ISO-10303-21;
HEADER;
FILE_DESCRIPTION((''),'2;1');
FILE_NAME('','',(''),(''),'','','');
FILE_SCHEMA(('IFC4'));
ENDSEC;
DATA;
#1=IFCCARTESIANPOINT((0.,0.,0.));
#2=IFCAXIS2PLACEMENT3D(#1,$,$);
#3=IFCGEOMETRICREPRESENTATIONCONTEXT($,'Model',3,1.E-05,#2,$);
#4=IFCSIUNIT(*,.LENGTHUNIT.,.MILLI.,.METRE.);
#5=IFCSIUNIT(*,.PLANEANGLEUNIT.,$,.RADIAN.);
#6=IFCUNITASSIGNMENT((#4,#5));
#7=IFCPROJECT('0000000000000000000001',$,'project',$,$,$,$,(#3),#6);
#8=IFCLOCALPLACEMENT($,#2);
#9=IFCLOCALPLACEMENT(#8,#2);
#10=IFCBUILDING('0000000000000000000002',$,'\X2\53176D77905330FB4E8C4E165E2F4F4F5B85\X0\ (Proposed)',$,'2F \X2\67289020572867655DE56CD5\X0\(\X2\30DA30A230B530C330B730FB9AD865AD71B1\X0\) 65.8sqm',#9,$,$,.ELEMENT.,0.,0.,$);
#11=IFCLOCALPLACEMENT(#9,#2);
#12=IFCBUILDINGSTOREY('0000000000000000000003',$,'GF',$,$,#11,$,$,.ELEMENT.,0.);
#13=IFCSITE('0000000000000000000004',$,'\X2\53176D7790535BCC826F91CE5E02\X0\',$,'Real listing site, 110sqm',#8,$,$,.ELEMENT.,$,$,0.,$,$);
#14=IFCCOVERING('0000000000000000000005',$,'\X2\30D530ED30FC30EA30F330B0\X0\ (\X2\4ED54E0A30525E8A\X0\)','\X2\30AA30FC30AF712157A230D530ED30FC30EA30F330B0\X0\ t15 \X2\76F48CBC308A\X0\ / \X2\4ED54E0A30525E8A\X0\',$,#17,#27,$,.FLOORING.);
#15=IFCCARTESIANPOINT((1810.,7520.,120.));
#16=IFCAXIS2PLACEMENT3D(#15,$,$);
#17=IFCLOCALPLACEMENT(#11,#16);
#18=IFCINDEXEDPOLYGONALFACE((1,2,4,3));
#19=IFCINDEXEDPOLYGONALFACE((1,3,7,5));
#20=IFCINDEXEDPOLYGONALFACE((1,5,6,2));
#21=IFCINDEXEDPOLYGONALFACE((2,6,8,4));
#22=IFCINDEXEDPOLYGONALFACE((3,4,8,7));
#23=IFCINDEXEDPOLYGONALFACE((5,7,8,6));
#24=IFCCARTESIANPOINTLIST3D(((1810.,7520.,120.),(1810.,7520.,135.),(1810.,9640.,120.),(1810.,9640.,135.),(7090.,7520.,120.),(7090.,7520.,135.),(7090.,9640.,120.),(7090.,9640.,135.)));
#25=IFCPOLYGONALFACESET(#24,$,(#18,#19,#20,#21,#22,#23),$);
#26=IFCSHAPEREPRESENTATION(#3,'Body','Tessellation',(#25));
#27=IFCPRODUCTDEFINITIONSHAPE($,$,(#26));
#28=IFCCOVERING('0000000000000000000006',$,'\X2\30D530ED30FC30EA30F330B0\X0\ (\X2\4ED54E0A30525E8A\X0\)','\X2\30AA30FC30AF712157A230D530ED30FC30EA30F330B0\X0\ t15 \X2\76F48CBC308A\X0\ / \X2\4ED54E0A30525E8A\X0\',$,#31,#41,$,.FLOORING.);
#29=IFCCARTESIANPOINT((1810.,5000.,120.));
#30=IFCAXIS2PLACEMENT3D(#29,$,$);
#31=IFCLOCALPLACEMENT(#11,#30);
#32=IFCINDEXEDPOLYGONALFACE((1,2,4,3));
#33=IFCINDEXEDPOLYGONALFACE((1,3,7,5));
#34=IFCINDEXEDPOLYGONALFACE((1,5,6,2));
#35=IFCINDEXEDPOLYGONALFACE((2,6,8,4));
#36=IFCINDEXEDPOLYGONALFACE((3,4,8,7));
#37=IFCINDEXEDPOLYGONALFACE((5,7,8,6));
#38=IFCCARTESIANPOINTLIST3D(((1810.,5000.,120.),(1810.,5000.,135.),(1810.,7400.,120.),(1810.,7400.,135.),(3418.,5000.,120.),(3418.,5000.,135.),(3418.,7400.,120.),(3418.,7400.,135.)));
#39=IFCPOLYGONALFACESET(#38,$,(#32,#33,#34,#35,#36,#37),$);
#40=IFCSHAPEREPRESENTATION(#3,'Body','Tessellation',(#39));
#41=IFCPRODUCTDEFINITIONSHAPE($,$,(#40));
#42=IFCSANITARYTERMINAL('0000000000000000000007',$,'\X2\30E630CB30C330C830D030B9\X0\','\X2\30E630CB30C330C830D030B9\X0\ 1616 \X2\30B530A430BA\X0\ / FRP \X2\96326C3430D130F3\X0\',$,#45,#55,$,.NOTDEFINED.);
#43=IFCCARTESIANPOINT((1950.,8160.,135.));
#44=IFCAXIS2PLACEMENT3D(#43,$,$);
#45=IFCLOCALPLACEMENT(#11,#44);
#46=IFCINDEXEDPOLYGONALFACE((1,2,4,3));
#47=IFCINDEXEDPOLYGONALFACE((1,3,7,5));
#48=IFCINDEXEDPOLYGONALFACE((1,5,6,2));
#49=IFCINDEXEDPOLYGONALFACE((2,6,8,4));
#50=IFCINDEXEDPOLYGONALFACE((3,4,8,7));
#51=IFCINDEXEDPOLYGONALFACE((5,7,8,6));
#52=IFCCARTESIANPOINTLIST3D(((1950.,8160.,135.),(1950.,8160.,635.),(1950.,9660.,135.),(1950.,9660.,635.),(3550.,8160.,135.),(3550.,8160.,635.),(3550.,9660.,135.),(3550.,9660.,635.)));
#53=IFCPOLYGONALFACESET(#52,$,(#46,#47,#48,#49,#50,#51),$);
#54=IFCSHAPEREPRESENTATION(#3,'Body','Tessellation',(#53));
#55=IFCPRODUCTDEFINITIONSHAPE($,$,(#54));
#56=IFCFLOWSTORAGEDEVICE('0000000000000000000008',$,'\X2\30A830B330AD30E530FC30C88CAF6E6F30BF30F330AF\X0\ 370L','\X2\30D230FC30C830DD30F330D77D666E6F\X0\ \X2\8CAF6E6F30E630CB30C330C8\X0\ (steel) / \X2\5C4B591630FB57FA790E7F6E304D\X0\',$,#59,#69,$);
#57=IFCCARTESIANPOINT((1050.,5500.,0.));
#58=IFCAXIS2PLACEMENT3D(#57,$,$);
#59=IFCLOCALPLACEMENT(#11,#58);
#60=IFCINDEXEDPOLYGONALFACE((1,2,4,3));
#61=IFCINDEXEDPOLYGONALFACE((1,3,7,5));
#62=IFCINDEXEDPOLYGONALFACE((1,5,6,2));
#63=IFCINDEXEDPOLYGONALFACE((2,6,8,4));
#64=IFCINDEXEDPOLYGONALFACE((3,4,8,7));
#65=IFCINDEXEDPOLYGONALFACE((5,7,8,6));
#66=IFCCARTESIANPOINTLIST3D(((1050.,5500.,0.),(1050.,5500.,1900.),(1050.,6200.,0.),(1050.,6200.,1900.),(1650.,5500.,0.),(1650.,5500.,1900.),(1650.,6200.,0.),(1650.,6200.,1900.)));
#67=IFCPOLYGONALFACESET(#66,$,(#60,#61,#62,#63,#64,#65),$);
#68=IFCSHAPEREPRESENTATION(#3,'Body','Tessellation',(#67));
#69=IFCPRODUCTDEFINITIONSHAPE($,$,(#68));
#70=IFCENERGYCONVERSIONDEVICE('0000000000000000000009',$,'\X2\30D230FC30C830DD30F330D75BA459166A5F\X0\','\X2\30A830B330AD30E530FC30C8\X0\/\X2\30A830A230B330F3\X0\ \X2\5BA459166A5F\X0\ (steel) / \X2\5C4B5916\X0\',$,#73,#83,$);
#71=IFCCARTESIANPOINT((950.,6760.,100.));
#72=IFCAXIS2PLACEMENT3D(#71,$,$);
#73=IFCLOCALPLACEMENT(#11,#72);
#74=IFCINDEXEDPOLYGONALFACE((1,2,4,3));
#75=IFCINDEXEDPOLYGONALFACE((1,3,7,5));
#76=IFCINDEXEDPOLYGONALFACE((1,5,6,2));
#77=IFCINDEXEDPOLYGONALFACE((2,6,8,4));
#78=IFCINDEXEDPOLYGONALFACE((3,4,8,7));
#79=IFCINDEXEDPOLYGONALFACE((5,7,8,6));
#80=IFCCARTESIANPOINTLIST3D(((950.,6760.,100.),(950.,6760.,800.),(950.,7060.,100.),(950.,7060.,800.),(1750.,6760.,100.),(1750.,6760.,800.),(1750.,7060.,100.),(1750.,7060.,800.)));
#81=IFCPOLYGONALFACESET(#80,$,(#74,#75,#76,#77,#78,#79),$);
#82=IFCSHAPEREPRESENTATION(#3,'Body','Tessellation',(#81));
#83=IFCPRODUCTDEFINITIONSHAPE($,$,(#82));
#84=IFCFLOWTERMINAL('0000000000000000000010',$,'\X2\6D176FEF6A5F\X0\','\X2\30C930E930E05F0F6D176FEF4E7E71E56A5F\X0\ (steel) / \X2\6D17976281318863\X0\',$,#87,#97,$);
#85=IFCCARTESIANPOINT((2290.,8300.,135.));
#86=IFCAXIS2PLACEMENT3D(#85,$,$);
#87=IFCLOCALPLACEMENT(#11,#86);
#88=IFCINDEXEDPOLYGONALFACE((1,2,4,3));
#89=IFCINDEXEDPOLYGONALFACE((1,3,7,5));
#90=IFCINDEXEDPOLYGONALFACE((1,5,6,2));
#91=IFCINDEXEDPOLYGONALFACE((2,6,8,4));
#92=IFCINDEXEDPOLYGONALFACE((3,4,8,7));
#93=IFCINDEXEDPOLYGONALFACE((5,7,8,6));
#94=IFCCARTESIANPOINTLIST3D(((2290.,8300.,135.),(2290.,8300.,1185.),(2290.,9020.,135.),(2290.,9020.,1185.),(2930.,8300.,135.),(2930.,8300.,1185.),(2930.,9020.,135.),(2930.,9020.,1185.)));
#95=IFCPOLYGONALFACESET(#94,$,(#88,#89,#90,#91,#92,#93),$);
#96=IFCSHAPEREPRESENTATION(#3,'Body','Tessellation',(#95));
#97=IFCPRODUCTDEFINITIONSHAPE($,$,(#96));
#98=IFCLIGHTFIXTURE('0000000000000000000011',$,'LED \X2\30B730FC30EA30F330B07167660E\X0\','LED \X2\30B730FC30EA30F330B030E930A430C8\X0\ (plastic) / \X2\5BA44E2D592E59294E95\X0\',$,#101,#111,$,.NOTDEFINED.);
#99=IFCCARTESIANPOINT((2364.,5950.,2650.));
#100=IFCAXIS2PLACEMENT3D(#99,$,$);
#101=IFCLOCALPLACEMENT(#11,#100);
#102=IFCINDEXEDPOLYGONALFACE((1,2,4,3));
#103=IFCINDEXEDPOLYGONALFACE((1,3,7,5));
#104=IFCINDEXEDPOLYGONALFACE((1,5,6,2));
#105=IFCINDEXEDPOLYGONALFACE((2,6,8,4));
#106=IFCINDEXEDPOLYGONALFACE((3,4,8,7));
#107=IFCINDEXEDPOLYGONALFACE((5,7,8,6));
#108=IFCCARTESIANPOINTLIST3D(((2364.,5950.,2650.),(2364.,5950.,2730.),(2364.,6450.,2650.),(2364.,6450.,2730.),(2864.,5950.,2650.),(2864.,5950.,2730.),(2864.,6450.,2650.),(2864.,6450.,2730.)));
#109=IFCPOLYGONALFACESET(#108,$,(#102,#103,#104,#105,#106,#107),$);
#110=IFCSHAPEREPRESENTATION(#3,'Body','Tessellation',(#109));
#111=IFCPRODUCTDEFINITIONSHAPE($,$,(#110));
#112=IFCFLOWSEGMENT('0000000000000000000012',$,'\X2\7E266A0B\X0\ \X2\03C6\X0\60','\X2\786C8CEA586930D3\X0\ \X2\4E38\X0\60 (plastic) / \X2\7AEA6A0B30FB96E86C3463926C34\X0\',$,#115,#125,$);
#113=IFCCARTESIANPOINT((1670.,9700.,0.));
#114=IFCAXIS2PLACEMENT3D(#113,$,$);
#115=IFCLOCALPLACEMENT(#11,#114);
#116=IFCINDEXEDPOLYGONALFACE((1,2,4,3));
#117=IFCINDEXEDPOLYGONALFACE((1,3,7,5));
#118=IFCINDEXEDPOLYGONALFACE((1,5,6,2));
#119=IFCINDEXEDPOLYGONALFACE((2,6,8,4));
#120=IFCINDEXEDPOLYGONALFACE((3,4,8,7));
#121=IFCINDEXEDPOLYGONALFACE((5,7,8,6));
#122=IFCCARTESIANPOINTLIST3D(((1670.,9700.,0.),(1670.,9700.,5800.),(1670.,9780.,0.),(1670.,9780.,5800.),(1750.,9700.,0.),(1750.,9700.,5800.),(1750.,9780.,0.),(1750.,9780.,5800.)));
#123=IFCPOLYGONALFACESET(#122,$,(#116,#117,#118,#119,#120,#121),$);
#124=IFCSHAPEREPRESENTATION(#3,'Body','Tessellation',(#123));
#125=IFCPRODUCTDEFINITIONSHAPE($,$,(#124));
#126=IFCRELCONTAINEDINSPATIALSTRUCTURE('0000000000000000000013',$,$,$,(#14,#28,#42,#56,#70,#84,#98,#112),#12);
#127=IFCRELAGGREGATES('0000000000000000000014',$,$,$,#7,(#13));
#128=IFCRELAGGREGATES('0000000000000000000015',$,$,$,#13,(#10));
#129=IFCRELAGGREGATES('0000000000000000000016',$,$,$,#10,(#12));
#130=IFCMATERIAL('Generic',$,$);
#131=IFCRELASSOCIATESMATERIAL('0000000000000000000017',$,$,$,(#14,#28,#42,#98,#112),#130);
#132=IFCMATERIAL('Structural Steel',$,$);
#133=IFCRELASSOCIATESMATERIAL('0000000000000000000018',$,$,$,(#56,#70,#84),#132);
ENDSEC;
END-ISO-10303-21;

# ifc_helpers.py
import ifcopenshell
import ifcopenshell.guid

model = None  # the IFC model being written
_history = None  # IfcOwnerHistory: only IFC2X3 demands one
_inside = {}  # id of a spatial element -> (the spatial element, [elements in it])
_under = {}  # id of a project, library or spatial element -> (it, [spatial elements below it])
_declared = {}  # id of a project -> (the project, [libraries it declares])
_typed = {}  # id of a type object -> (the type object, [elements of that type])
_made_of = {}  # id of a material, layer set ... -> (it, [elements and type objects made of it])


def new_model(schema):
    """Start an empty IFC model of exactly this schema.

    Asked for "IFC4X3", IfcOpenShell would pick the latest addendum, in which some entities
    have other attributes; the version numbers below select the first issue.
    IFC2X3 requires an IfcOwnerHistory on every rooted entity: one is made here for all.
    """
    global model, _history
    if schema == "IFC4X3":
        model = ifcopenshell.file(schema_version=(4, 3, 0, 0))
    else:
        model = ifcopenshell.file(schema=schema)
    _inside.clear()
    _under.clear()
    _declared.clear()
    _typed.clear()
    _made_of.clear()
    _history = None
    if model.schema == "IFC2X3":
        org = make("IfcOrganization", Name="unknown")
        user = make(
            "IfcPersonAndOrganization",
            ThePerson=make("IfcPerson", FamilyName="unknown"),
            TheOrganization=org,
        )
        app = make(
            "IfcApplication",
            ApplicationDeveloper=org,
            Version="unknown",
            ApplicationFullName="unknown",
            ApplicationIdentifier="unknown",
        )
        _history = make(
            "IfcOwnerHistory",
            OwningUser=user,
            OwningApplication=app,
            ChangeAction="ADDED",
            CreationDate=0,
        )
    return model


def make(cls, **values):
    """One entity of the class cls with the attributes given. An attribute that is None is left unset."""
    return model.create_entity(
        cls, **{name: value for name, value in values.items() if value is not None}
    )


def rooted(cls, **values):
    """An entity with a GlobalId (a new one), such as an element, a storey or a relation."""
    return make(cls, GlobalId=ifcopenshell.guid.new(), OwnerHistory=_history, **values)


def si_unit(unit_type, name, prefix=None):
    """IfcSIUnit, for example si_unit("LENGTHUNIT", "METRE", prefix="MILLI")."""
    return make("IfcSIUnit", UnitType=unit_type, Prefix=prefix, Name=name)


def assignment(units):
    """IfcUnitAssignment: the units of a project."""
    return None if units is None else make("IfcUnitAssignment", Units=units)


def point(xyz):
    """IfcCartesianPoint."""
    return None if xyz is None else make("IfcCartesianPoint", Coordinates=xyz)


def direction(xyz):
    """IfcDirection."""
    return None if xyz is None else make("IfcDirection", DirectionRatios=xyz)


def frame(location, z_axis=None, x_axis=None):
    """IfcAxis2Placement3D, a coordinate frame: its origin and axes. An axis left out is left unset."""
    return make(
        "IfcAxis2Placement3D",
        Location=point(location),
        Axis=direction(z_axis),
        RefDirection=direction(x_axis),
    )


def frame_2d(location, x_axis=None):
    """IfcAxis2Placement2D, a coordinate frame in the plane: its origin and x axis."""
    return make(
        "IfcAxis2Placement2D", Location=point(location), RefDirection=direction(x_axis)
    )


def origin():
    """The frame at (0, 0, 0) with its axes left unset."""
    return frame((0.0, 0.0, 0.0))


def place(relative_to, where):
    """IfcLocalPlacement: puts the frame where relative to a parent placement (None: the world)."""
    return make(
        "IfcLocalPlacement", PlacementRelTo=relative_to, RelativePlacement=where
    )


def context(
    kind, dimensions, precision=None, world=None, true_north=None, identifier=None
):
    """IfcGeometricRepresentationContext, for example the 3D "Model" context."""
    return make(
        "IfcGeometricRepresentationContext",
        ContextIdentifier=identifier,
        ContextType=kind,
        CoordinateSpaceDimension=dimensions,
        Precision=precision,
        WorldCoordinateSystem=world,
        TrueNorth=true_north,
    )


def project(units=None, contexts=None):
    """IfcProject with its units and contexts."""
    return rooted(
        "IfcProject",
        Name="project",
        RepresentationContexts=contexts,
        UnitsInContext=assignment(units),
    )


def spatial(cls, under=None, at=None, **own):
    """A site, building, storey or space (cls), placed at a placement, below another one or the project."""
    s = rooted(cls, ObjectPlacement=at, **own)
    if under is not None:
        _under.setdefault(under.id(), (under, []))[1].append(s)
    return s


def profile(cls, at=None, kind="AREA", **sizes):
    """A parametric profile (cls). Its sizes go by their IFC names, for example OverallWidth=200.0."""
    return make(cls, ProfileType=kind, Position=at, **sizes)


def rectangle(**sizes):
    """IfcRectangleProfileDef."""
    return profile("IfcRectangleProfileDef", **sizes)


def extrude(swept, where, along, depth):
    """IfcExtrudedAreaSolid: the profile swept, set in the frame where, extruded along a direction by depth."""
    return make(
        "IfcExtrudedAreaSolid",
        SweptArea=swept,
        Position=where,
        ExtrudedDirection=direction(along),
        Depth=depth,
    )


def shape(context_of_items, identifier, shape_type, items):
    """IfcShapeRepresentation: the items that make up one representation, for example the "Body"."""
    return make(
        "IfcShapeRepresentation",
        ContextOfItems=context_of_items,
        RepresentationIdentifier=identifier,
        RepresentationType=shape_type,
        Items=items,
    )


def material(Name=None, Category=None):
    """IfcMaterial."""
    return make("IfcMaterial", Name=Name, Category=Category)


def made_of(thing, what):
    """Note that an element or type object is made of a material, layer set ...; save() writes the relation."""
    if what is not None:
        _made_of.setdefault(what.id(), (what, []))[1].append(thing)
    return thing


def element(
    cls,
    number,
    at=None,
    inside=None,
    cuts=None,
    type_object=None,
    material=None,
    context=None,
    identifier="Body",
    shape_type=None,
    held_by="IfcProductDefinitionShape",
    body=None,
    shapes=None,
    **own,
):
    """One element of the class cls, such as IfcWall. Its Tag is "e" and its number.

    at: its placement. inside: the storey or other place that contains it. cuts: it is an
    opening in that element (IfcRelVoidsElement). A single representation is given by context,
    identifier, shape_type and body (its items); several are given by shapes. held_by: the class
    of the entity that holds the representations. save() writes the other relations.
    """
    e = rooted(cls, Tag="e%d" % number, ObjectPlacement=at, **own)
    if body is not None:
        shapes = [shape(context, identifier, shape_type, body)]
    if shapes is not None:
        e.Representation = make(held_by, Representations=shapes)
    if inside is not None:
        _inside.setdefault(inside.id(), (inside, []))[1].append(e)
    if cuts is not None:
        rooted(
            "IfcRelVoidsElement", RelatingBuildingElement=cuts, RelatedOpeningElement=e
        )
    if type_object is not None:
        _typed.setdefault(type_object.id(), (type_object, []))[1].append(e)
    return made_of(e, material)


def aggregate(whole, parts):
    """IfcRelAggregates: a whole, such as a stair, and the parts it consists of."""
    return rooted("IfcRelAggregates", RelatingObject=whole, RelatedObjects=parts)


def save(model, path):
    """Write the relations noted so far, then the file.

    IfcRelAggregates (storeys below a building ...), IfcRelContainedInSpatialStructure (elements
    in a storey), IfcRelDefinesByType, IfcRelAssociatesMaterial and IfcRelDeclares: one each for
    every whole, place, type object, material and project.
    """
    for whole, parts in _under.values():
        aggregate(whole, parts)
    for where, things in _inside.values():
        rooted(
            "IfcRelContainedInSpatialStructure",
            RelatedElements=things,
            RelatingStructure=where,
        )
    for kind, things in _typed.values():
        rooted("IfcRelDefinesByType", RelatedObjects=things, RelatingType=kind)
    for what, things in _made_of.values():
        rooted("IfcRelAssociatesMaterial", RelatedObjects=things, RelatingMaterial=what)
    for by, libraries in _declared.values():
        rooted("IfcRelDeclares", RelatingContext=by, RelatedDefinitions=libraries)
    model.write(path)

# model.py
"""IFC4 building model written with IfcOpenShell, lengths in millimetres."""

from ifc_helpers import new_model, si_unit, frame, frame_2d, origin, place, context, project, spatial, rectangle, extrude, material, element, save


model = new_model("IFC4")

# Units and contexts
model_context = context("Model", 3, precision=1e-05, world=origin())
ifc_project = project(units=[si_unit("LENGTHUNIT", "METRE", prefix="MILLI"), si_unit("PLANEANGLEUNIT", "RADIAN")], contexts=[model_context])

# Site, building, storey
site_placement = place(None, origin())
site = spatial("IfcSite", under=ifc_project, at=site_placement, Name="北海道富良野市", ObjectType="Real listing site, 110sqm", CompositionType="ELEMENT", RefElevation=0.0)
building_placement = place(site_placement, origin())
building = spatial("IfcBuilding", under=site, at=building_placement, Name="北海道・二世帯住宅 (Proposed)", ObjectType="2F 木造在来工法(ペアサッシ・高断熱) 65.8sqm", CompositionType="ELEMENT", ElevationOfRefHeight=0.0, ElevationOfTerrain=0.0)
storey_placement = place(building_placement, origin())
storey = spatial("IfcBuildingStorey", under=building, at=storey_placement, Name="GF", CompositionType="ELEMENT", Elevation=0.0)

# Coverings
ifc_material_1 = material(Name="Generic")
covering_1_placement = place(storey_placement, frame((1810.0, 7520.0, 120.0)))
element("IfcCovering", 1, at=covering_1_placement, inside=storey, material=ifc_material_1, Name="フローリング (仕上げ床)", Description="オーク無垢フローリング t15 直貼り / 仕上げ床", PredefinedType="FLOORING", context=model_context, shape_type="SweptSolid", body=[
    extrude(rectangle(XDim=5280.0, YDim=2120.0, at=frame_2d((2640.0, 1060.0))), frame((1810.0, 7520.0, 120.0)), (0.0, 0.0, 1.0), 15.0),
])
covering_2_placement = place(storey_placement, frame((1810.0, 5000.0, 120.0)))
element("IfcCovering", 2, at=covering_2_placement, inside=storey, material=ifc_material_1, Name="フローリング (仕上げ床)", Description="オーク無垢フローリング t15 直貼り / 仕上げ床", PredefinedType="FLOORING", context=model_context, shape_type="SweptSolid", body=[
    extrude(rectangle(XDim=1608.0, YDim=2400.0, at=frame_2d((804.0, 1200.0))), frame((1810.0, 5000.0, 120.0)), (0.0, 0.0, 1.0), 15.0),
])

# Sanitary terminal
sanitary_terminal_placement = place(storey_placement, frame((1950.0, 8160.0, 135.0)))
element("IfcSanitaryTerminal", 3, at=sanitary_terminal_placement, inside=storey, material=ifc_material_1, Name="ユニットバス", Description="ユニットバス 1616 サイズ / FRP 防水パン", PredefinedType="NOTDEFINED", context=model_context, shape_type="SweptSolid", body=[
    extrude(rectangle(XDim=1600.0, YDim=1500.0, at=frame_2d((800.0, 750.0))), frame((1950.0, 8160.0, 135.0)), (0.0, 0.0, 1.0), 500.0),
])

# Flow storage device
ifc_material_2 = material(Name="Structural Steel")
flow_storage_device_placement = place(storey_placement, frame((1050.0, 5500.0, 0.0)))
element("IfcFlowStorageDevice", 4, at=flow_storage_device_placement, inside=storey, material=ifc_material_2, Name="エコキュート貯湯タンク 370L", Description="ヒートポンプ給湯 貯湯ユニット (steel) / 屋外・基礎置き", context=model_context, shape_type="SweptSolid", body=[
    extrude(rectangle(XDim=600.0, YDim=700.0, at=frame_2d((300.0, 350.0))), frame((1050.0, 5500.0, 0.0)), (0.0, 0.0, 1.0), 1900.0),
])

# Energy conversion device
energy_conversion_device_placement = place(storey_placement, frame((950.0, 6760.0, 100.0)))
element("IfcEnergyConversionDevice", 5, at=energy_conversion_device_placement, inside=storey, material=ifc_material_2, Name="ヒートポンプ室外機", Description="エコキュート/エアコン 室外機 (steel) / 屋外", context=model_context, shape_type="SweptSolid", body=[
    extrude(rectangle(XDim=800.0, YDim=300.0, at=frame_2d((400.0, 150.0))), frame((950.0, 6760.0, 100.0)), (0.0, 0.0, 1.0), 700.0),
])

# Flow terminal
flow_terminal_placement = place(storey_placement, frame((2290.0, 8300.0, 135.0)))
element("IfcFlowTerminal", 6, at=flow_terminal_placement, inside=storey, material=ifc_material_2, Name="洗濯機", Description="ドラム式洗濯乾燥機 (steel) / 洗面脱衣", context=model_context, shape_type="SweptSolid", body=[
    extrude(rectangle(XDim=640.0, YDim=720.0, at=frame_2d((320.0, 360.0))), frame((2290.0, 8300.0, 135.0)), (0.0, 0.0, 1.0), 1050.0),
])

# Light fixture
light_fixture_placement = place(storey_placement, frame((2364.0, 5950.0, 2650.0)))
element("IfcLightFixture", 7, at=light_fixture_placement, inside=storey, material=ifc_material_1, Name="LED シーリング照明", Description="LED シーリングライト (plastic) / 室中央天井", PredefinedType="NOTDEFINED", context=model_context, shape_type="SweptSolid", body=[
    extrude(rectangle(XDim=500.0, YDim=500.0, at=frame_2d((250.0, 250.0))), frame((2364.0, 5950.0, 2650.0)), (0.0, 0.0, 1.0), 80.0),
])

# Flow segment
flow_segment_placement = place(storey_placement, frame((1670.0, 9700.0, 0.0)))
element("IfcFlowSegment", 8, at=flow_segment_placement, inside=storey, material=ifc_material_1, Name="縦樋 φ60", Description="硬質塩ビ 丸60 (plastic) / 竪樋・雨水排水", context=model_context, shape_type="SweptSolid", body=[
    extrude(rectangle(XDim=80.0, YDim=80.0, at=frame_2d((40.0, 40.0))), frame((1670.0, 9700.0, 0.0)), (0.0, 0.0, 1.0), 5800.0),
])

save(model, "model.ifc")
